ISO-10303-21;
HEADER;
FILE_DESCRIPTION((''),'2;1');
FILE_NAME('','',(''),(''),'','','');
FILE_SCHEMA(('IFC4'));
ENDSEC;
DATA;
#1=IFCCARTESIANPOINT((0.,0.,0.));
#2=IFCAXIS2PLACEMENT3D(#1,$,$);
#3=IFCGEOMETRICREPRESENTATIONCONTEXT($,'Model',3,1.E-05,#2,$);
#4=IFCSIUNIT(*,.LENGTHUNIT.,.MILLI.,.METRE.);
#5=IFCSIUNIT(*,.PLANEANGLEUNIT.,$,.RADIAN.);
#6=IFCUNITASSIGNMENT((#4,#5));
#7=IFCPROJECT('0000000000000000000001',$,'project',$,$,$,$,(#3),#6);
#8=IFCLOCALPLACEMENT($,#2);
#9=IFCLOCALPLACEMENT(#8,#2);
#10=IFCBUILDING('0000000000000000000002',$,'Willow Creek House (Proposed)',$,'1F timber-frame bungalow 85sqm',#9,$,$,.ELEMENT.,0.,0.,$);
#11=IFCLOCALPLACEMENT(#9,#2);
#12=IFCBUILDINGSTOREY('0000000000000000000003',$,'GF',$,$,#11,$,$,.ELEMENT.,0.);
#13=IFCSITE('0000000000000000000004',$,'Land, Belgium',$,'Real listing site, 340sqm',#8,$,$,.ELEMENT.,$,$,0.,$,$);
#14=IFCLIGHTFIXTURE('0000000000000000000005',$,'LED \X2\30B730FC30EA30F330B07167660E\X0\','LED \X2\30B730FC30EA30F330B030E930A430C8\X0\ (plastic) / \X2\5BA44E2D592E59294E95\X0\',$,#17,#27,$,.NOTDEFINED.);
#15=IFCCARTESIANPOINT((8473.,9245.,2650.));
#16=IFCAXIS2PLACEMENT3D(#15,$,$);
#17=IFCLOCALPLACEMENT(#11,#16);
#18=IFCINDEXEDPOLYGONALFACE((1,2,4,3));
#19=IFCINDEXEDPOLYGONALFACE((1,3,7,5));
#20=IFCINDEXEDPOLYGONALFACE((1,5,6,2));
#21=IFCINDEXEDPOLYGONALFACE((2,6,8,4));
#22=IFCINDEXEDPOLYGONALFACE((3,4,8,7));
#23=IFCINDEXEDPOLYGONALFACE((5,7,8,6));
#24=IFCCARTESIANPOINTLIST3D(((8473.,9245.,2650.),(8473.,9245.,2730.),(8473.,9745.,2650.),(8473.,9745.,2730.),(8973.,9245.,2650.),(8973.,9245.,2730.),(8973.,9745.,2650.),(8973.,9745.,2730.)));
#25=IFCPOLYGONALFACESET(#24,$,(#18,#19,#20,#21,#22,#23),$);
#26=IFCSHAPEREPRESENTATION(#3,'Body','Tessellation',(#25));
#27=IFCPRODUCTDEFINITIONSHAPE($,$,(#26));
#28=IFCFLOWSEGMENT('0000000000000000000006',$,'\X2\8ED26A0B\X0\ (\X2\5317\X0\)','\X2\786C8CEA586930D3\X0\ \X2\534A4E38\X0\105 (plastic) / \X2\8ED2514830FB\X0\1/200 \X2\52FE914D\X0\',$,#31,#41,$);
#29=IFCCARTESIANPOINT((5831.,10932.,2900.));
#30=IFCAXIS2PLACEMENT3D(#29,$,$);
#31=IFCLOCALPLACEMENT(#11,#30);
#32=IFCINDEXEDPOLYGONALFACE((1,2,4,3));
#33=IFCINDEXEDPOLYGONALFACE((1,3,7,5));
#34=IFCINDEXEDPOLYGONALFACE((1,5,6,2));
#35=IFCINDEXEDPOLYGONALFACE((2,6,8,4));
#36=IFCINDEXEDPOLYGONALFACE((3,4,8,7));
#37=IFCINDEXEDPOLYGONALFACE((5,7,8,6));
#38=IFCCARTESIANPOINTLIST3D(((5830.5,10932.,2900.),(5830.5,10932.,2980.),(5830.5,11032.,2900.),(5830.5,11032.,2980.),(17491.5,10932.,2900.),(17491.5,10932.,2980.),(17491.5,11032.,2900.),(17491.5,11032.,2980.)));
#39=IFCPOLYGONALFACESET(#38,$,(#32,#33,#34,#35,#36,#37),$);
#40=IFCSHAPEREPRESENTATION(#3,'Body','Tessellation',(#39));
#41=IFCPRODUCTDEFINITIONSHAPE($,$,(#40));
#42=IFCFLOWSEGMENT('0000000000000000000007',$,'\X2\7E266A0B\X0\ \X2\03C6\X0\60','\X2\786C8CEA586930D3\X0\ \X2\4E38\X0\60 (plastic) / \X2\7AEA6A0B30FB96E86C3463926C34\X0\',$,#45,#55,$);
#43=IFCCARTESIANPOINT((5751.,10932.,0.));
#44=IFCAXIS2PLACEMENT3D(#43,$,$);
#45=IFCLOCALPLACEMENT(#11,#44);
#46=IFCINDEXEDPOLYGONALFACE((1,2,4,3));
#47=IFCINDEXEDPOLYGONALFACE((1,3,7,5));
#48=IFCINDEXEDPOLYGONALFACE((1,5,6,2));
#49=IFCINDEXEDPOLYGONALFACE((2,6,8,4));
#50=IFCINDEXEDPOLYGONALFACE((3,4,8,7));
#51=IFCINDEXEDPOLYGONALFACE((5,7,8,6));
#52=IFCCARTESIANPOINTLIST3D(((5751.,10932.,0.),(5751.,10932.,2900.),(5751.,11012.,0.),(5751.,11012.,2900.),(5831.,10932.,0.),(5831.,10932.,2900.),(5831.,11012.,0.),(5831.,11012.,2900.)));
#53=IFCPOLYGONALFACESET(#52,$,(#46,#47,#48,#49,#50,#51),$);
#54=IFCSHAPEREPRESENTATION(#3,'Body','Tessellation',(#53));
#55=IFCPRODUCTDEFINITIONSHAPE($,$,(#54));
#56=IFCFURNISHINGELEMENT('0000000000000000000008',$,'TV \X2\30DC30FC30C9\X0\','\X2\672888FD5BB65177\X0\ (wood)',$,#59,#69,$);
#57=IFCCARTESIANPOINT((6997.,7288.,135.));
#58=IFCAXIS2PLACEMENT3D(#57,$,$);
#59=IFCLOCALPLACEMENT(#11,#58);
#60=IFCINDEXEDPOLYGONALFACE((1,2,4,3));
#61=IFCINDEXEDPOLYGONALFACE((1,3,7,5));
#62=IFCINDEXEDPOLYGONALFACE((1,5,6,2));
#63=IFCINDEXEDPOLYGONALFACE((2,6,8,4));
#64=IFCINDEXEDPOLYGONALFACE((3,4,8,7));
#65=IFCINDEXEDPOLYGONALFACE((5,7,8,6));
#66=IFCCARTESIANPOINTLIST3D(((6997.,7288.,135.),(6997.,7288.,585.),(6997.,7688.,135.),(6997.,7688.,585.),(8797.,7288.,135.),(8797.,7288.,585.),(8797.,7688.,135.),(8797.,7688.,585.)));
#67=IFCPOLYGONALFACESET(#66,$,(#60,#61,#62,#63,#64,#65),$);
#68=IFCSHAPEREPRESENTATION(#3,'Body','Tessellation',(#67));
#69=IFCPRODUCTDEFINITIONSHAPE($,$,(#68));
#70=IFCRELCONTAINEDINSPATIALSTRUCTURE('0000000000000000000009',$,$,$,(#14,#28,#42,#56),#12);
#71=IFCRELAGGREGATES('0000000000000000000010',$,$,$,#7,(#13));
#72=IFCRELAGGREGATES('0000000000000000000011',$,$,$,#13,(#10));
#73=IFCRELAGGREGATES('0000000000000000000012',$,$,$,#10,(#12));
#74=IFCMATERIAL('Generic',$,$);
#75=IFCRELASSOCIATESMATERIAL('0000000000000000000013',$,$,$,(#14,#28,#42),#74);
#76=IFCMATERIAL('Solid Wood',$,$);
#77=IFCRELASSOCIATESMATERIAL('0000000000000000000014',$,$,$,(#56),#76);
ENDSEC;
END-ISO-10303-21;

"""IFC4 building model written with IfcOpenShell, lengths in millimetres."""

from ifc_helpers import new_model, si_unit, frame, frame_2d, origin, place, context, project, spatial, rectangle, extrude, material, element, save


model = new_model("IFC4")

# Units and contexts
model_context = context("Model", 3, precision=1e-05, world=origin())
ifc_project = project(units=[si_unit("LENGTHUNIT", "METRE", prefix="MILLI"), si_unit("PLANEANGLEUNIT", "RADIAN")], contexts=[model_context])

# Site, building, storey
site_placement = place(None, origin())
site = spatial("IfcSite", under=ifc_project, at=site_placement, Name="Land, Belgium", ObjectType="Real listing site, 340sqm", CompositionType="ELEMENT", RefElevation=0.0)
building_placement = place(site_placement, origin())
building = spatial("IfcBuilding", under=site, at=building_placement, Name="Willow Creek House (Proposed)", ObjectType="1F timber-frame bungalow 85sqm", CompositionType="ELEMENT", ElevationOfRefHeight=0.0, ElevationOfTerrain=0.0)
storey_placement = place(building_placement, origin())
storey = spatial("IfcBuildingStorey", under=building, at=storey_placement, Name="GF", CompositionType="ELEMENT", Elevation=0.0)

# Shared definitions
ifc_material_1 = material(Name="Solid Wood")

# Shared definitions
ifc_material_2 = material(Name="Generic")

# Light fixture
light_fixture_placement = place(storey_placement, frame((8473.0, 9245.0, 2650.0)))
element("IfcLightFixture", 1, at=light_fixture_placement, inside=storey, material=ifc_material_2, Name="LED シーリング照明", Description="LED シーリングライト (plastic) / 室中央天井", PredefinedType="NOTDEFINED", context=model_context, shape_type="SweptSolid", body=[
    extrude(rectangle(XDim=500.0, YDim=500.0, at=frame_2d((250.0, 250.0))), frame((8473.0, 9245.0, 2650.0)), (0.0, 0.0, 1.0), 80.0),
])

# Flow segments
flow_segment_1_placement = place(storey_placement, frame((5831.0, 10932.0, 2900.0)))
element("IfcFlowSegment", 2, at=flow_segment_1_placement, inside=storey, material=ifc_material_2, Name="軒樋 (北)", Description="硬質塩ビ 半丸105 (plastic) / 軒先・1/200 勾配", context=model_context, shape_type="SweptSolid", body=[
    extrude(rectangle(XDim=11661.0, YDim=100.0, at=frame_2d((5830.0, 50.0))), frame((5831.0, 10932.0, 2900.0)), (0.0, 0.0, 1.0), 80.0),
])
flow_segment_2_placement = place(storey_placement, frame((5751.0, 10932.0, 0.0)))
element("IfcFlowSegment", 3, at=flow_segment_2_placement, inside=storey, material=ifc_material_2, Name="縦樋 φ60", Description="硬質塩ビ 丸60 (plastic) / 竪樋・雨水排水", context=model_context, shape_type="SweptSolid", body=[
    extrude(rectangle(XDim=80.0, YDim=80.0, at=frame_2d((40.0, 40.0))), frame((5751.0, 10932.0, 0.0)), (0.0, 0.0, 1.0), 2900.0),
])

# Furnishing element
furnishing_placement = place(storey_placement, frame((6997.0, 7288.0, 135.0)))
element("IfcFurnishingElement", 4, at=furnishing_placement, inside=storey, material=ifc_material_1, Name="TV ボード", Description="木製家具 (wood)", context=model_context, shape_type="SweptSolid", body=[
    extrude(rectangle(XDim=1800.0, YDim=400.0, at=frame_2d((900.0, 200.0))), frame((6997.0, 7288.0, 135.0)), (0.0, 0.0, 1.0), 450.0),
])

save(model, "model.ifc")
